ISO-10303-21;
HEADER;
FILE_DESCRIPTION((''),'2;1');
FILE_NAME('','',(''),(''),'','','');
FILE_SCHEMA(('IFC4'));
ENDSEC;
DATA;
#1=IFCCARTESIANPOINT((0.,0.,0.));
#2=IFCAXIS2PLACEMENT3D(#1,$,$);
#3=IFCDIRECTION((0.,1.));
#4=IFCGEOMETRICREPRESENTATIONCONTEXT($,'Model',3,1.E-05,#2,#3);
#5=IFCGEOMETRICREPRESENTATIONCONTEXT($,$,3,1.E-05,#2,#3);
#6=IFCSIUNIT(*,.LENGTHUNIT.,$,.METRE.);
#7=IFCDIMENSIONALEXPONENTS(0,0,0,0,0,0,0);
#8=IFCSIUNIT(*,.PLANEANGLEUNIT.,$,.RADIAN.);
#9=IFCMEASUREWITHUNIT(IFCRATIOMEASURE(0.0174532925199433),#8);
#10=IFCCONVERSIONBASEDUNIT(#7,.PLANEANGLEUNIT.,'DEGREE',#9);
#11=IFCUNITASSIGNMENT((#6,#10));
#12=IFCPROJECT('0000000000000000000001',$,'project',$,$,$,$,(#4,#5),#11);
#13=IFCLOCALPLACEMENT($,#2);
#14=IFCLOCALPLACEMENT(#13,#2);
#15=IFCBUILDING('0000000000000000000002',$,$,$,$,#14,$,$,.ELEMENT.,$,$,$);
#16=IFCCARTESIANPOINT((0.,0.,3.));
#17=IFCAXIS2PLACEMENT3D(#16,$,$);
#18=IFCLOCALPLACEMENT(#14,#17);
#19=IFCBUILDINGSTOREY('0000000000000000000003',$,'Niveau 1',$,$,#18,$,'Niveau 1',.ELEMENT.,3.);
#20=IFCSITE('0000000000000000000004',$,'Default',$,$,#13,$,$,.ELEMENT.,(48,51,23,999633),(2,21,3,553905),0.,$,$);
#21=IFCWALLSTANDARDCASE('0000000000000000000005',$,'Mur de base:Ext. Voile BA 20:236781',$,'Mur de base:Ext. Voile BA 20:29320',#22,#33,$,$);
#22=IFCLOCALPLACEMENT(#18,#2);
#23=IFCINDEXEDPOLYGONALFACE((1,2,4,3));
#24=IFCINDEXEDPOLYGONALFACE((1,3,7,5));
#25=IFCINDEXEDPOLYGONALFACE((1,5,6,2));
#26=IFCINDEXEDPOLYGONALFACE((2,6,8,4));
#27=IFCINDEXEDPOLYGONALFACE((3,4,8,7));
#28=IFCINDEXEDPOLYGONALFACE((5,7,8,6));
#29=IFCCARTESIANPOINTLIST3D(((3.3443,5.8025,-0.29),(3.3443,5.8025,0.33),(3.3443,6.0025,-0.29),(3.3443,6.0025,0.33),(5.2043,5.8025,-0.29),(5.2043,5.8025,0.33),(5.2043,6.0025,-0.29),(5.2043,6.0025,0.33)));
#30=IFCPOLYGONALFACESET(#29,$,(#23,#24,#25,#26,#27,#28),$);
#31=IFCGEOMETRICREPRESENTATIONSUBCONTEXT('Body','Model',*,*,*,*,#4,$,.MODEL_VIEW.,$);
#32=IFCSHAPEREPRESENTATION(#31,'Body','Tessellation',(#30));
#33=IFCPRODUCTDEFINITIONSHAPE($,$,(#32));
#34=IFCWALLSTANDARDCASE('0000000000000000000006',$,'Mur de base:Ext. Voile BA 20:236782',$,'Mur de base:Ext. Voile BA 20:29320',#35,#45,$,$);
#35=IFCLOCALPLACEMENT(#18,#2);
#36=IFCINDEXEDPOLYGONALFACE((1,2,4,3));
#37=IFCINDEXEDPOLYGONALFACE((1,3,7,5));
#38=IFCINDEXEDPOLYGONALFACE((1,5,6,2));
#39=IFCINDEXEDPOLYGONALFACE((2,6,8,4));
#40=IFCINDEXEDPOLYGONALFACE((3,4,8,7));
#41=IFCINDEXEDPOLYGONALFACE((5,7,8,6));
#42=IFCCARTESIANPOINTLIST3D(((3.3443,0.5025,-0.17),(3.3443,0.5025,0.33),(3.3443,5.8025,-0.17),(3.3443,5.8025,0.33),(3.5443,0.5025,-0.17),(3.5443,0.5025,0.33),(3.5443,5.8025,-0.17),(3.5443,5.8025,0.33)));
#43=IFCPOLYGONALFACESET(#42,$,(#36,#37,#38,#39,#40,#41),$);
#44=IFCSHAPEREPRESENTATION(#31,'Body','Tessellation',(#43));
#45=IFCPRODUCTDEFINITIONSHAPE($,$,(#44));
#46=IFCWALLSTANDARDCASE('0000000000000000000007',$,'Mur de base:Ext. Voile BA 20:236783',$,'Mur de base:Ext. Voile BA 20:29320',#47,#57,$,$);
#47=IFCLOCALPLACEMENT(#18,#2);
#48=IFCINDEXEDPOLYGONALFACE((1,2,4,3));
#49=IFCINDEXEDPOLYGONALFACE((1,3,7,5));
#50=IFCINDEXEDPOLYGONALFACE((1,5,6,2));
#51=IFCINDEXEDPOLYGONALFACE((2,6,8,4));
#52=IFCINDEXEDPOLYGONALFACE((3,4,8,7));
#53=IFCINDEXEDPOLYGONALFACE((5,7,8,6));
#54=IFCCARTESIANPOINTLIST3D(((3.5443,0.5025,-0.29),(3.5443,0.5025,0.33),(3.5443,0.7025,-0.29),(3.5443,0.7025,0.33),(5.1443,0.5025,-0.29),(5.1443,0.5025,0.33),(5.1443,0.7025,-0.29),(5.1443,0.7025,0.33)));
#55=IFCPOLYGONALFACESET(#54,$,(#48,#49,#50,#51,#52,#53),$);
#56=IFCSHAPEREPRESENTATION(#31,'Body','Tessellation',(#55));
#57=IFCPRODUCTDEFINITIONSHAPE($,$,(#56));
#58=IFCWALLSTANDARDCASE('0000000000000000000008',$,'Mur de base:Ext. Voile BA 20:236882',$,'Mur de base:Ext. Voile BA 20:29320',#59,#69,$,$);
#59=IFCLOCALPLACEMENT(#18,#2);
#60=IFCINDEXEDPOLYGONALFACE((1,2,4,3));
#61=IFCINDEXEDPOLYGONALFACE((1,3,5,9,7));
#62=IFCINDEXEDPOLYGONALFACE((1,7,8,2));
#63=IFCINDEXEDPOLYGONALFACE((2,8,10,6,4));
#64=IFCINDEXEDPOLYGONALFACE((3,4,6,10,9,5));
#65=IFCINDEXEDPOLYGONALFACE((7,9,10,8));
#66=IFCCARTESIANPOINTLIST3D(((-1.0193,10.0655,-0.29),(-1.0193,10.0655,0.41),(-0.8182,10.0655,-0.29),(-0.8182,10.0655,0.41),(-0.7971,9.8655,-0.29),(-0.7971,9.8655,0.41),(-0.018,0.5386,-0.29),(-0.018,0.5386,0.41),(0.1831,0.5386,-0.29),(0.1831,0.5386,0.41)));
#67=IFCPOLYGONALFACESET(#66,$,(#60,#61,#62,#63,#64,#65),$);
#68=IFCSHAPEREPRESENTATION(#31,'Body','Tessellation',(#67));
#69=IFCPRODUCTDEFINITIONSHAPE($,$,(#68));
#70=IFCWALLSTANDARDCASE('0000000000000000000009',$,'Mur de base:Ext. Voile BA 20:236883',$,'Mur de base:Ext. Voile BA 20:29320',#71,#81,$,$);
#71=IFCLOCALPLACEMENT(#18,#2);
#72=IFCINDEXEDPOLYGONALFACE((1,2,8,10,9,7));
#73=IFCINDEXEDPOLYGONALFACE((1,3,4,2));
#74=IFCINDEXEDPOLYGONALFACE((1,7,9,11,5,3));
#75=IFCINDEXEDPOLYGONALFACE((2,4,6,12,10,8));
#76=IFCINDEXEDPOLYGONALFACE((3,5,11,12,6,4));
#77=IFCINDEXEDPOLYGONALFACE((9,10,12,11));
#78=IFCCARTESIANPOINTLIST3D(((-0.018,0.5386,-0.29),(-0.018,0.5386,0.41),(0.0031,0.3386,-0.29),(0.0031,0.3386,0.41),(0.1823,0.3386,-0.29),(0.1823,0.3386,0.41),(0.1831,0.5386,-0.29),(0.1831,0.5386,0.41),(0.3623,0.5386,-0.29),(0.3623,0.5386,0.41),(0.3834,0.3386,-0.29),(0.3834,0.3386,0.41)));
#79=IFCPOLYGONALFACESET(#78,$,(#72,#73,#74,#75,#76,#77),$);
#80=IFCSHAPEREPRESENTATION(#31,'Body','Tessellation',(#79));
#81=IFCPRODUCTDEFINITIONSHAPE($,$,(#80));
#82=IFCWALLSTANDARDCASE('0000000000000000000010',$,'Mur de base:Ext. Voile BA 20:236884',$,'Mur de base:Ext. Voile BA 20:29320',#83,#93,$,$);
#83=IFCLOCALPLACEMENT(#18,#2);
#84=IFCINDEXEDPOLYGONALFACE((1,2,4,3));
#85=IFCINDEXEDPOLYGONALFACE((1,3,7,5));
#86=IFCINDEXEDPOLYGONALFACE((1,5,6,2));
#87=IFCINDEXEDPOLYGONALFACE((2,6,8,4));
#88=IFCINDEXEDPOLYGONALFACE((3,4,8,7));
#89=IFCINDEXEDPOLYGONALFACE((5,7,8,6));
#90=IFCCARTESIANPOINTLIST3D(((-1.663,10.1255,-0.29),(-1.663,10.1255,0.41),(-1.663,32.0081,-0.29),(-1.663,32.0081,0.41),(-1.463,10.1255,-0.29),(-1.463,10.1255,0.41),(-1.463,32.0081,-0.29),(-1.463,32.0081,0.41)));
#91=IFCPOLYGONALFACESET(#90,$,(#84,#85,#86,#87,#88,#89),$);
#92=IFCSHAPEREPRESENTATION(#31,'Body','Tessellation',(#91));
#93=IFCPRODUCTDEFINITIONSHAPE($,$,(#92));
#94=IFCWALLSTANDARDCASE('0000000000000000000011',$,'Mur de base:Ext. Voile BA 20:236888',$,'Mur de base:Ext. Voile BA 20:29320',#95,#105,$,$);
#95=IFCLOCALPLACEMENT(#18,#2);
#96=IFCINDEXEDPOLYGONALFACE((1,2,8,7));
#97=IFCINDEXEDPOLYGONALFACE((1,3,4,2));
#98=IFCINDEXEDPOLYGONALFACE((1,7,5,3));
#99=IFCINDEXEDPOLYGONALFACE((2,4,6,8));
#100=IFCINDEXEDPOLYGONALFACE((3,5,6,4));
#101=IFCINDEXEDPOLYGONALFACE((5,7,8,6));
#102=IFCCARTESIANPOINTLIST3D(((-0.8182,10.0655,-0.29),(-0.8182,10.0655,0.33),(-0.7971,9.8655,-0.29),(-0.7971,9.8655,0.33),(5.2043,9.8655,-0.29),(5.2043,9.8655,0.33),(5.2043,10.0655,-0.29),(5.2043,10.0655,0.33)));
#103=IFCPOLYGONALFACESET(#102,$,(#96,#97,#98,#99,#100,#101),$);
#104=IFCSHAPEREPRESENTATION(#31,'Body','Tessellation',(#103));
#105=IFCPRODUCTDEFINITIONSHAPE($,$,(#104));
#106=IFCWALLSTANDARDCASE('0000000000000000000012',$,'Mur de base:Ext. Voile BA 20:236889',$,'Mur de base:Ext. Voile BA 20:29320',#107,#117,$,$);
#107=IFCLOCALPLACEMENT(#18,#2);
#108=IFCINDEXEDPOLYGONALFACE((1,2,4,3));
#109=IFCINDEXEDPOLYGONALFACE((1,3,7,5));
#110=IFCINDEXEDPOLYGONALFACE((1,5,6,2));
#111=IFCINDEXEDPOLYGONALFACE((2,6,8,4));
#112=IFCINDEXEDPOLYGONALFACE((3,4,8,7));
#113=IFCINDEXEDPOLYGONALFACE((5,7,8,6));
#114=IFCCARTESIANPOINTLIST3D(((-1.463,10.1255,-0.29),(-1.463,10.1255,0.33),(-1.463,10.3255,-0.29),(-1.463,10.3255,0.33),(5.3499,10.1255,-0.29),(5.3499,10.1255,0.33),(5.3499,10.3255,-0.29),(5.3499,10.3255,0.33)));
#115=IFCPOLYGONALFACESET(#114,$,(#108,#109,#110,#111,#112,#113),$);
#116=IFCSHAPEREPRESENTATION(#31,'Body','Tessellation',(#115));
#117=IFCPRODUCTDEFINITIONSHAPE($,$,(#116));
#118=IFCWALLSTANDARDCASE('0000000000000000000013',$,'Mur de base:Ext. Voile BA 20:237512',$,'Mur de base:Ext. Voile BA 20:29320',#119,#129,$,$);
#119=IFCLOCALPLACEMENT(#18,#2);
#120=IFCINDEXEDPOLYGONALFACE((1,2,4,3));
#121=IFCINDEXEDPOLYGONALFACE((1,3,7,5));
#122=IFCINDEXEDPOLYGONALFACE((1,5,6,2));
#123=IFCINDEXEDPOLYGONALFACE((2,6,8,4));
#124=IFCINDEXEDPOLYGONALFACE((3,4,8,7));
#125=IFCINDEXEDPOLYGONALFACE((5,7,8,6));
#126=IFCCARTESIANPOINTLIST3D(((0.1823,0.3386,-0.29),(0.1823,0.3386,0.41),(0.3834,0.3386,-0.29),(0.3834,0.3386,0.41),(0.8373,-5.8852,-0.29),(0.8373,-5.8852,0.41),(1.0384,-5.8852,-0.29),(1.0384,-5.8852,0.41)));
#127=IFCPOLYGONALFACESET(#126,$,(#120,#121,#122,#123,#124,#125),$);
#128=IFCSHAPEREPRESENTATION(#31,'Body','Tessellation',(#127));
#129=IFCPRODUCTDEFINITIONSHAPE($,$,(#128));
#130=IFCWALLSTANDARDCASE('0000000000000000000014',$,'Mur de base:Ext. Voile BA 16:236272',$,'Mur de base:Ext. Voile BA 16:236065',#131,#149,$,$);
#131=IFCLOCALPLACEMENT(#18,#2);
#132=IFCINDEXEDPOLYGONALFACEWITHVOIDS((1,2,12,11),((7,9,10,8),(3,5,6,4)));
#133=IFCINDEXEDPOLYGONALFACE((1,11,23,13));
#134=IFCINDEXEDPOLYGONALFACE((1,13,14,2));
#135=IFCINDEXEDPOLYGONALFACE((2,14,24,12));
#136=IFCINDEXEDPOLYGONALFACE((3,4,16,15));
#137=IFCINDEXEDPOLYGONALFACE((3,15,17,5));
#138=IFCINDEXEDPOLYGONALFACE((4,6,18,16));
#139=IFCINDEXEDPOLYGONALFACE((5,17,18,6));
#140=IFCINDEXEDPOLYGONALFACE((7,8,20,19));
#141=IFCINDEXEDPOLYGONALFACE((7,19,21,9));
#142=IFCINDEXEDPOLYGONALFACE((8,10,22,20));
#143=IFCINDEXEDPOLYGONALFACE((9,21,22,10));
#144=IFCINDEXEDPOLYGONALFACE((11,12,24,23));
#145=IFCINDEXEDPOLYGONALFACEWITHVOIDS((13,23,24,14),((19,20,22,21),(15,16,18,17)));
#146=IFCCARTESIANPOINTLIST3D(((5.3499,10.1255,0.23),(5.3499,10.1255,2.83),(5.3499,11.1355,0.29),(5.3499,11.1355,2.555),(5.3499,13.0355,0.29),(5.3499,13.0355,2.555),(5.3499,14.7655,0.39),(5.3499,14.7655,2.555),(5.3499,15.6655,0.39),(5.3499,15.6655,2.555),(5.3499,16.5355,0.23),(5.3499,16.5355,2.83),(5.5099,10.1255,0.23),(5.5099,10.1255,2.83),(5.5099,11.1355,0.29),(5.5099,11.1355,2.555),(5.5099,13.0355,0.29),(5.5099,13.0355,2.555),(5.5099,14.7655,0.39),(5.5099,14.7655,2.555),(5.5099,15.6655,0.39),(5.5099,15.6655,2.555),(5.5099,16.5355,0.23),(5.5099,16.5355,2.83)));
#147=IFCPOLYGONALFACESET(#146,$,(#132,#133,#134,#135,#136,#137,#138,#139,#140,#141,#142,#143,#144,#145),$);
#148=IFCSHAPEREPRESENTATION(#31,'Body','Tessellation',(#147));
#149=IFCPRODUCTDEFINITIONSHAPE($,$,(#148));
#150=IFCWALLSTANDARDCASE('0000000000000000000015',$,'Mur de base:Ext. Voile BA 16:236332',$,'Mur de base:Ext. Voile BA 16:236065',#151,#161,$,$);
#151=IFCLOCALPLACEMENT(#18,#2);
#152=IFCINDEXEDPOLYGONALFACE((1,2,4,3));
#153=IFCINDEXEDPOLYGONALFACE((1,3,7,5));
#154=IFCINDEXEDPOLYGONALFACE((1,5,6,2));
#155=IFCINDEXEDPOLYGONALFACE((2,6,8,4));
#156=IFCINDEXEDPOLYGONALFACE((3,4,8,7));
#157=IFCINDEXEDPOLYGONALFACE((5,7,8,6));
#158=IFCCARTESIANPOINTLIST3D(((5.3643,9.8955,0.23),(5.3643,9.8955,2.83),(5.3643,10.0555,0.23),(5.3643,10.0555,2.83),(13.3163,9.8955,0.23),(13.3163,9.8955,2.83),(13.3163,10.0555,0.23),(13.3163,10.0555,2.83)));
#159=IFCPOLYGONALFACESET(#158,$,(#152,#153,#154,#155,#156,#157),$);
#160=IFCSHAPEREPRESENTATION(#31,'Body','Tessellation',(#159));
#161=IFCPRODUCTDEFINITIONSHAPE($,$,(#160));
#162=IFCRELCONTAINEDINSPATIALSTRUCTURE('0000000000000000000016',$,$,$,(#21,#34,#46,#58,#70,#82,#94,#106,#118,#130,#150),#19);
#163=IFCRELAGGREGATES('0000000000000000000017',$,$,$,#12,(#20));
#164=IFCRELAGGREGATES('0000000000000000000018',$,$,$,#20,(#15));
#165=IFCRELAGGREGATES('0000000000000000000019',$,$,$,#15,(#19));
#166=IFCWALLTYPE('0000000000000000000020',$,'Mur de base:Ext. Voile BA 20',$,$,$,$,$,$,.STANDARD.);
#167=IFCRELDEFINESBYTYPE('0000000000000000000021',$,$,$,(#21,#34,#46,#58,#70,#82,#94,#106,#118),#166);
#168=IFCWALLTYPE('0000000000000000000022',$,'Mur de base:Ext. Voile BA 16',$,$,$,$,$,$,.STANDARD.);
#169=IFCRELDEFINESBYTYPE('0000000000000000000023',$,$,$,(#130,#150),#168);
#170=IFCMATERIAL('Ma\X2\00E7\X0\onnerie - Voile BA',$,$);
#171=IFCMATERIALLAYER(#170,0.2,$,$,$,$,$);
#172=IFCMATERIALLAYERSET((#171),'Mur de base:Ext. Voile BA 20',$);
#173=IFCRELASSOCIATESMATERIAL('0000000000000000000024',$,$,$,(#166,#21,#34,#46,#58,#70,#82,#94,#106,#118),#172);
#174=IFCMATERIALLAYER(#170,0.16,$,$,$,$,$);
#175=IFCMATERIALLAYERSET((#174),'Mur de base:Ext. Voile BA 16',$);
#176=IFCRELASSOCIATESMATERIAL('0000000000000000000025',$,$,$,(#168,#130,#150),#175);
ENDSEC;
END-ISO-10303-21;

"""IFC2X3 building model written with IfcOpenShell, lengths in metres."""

from ifc_helpers import new_model, entity, si_unit, converted_unit, direction, frame, frame_2d, origin, place, context, subcontext, project, spatial, polyline, rectangle, outline, extrude, material, layer, layer_set, layer_usage, type_object, element, save


model = new_model("IFC2X3")

# Units and contexts
model_context = context("Model", 3, precision=1e-05, world=origin(), true_north=direction((0.0, 1.0)))
context_of_model = context(None, 3, precision=1e-05, world=origin(), true_north=direction((0.0, 1.0)))
body_context = subcontext(model_context, "Body", "Model", "MODEL_VIEW")
ifc_project = project(units=[si_unit("LENGTHUNIT", "METRE"), converted_unit("PLANEANGLEUNIT", "DEGREE", entity("IfcRatioMeasure", 0.0174532925199433), si_unit("PLANEANGLEUNIT", "RADIAN"), dimensions=[0, 0, 0, 0, 0, 0, 0])], contexts=[model_context, context_of_model])

# Site, building, storey
site_placement = place(None, origin())
site = spatial("IfcSite", under=ifc_project, at=site_placement, Name="Default", CompositionType="ELEMENT", RefLatitude=(48, 51, 23, 999633), RefLongitude=(2, 21, 3, 553905), RefElevation=0.0)
building_placement = place(site_placement, origin())
building = spatial("IfcBuilding", under=site, at=building_placement, CompositionType="ELEMENT")
storey_placement = place(building_placement, frame((0.0, 0.0, 3.0)))
storey = spatial("IfcBuildingStorey", under=building, at=storey_placement, Name="Niveau 1", LongName="Niveau 1", CompositionType="ELEMENT", Elevation=3.0)

# Shared definitions
ifc_material_1 = material(Name="Maçonnerie - Voile BA")
ifc_layer_1 = layer(ifc_material_1, 0.2)
ifc_layer_set_1 = layer_set([ifc_layer_1], Name="Mur de base:Ext. Voile BA 20")
wall_type_1 = type_object("IfcWallType", Name="Mur de base:Ext. Voile BA 20", PredefinedType="STANDARD", material=ifc_layer_set_1)

# Walls
ifc_layer_usage_1 = layer_usage(ifc_layer_set_1, "AXIS2", "NEGATIVE", 0.1)
wall_1_placement = place(storey_placement, frame((5.2043, 5.9025, -0.29), z_axis=(0.0, 0.0, 1.0), x_axis=(-1.0, 0.0, 0.0)))
element("IfcWallStandardCase", 1, at=wall_1_placement, inside=storey, type_object=wall_type_1, material=ifc_layer_usage_1, Name="Mur de base:Ext. Voile BA 20:236781", ObjectType="Mur de base:Ext. Voile BA 20:29320", context=body_context, shape_type="SweptSolid", body=[
    extrude(rectangle(XDim=1.86, YDim=0.2, at=frame_2d((0.93, 0.0), x_axis=(-1.0, 0.0))), origin(), (0.0, 0.0, 1.0), 0.62),
])
ifc_layer_usage_2 = layer_usage(ifc_layer_set_1, "AXIS2", "NEGATIVE", 0.1)
wall_2_placement = place(storey_placement, frame((3.4443, 5.8025, -0.17), z_axis=(0.0, 0.0, 1.0), x_axis=(0.0, -1.0, 0.0)))
element("IfcWallStandardCase", 2, at=wall_2_placement, inside=storey, type_object=wall_type_1, material=ifc_layer_usage_2, Name="Mur de base:Ext. Voile BA 20:236782", ObjectType="Mur de base:Ext. Voile BA 20:29320", context=body_context, shape_type="SweptSolid", body=[
    extrude(rectangle(XDim=5.3, YDim=0.2, at=frame_2d((2.65, 0.0), x_axis=(-1.0, 0.0))), origin(), (0.0, 0.0, 1.0), 0.5),
])
ifc_layer_usage_3 = layer_usage(ifc_layer_set_1, "AXIS2", "NEGATIVE", 0.1)
wall_3_placement = place(storey_placement, frame((3.5443, 0.6025, -0.29)))
element("IfcWallStandardCase", 3, at=wall_3_placement, inside=storey, type_object=wall_type_1, material=ifc_layer_usage_3, Name="Mur de base:Ext. Voile BA 20:236783", ObjectType="Mur de base:Ext. Voile BA 20:29320", context=body_context, shape_type="SweptSolid", body=[
    extrude(rectangle(XDim=1.6, YDim=0.2, at=frame_2d((0.8, 0.0), x_axis=(-1.0, 0.0))), origin(), (0.0, 0.0, 1.0), 0.62),
])
ifc_layer_usage_4 = layer_usage(ifc_layer_set_1, "AXIS2", "NEGATIVE", 0.1)
wall_4_placement = place(storey_placement, frame((0.0837, 0.5282, -0.29), z_axis=(0.0, 0.0, 1.0), x_axis=(-0.104528, 0.994522, 0.0)))
element("IfcWallStandardCase", 4, at=wall_4_placement, inside=storey, type_object=wall_type_1, material=ifc_layer_usage_4, Name="Mur de base:Ext. Voile BA 20:236882", ObjectType="Mur de base:Ext. Voile BA 20:29320", context=body_context, shape_type="SweptSolid", body=[
    extrude(outline(polyline([(9.5793, -0.1), (9.6003, 0.1), (0.021, 0.1), (0.0, -0.1), (9.3782, -0.1), (9.5793, -0.1)])), origin(), (0.0, 0.0, 1.0), 0.7),
])
ifc_layer_usage_5 = layer_usage(ifc_layer_set_1, "AXIS2", "POSITIVE", -0.1)
wall_5_placement = place(storey_placement, frame((-0.018, 0.4386, -0.29)))
element("IfcWallStandardCase", 5, at=wall_5_placement, inside=storey, type_object=wall_type_1, material=ifc_layer_usage_5, Name="Mur de base:Ext. Voile BA 20:236883", ObjectType="Mur de base:Ext. Voile BA 20:29320", context=body_context, shape_type="SweptSolid", body=[
    extrude(outline(polyline([(0.4013, -0.1), (0.3803, 0.1), (0.2011, 0.1), (0.0, 0.1), (0.021, -0.1), (0.2002, -0.1), (0.4013, -0.1)])), origin(), (0.0, 0.0, 1.0), 0.7),
])
ifc_layer_usage_6 = layer_usage(ifc_layer_set_1, "AXIS2", "NEGATIVE", 0.1)
wall_6_placement = place(storey_placement, frame((-1.563, 10.1255, -0.29), z_axis=(0.0, 0.0, 1.0), x_axis=(0.0, 1.0, 0.0)))
element("IfcWallStandardCase", 6, at=wall_6_placement, inside=storey, type_object=wall_type_1, material=ifc_layer_usage_6, Name="Mur de base:Ext. Voile BA 20:236884", ObjectType="Mur de base:Ext. Voile BA 20:29320", context=body_context, shape_type="SweptSolid", body=[
    extrude(rectangle(XDim=21.8826, YDim=0.2, at=frame_2d((10.9413, 0.0), x_axis=(-1.0, 0.0))), origin(), (0.0, 0.0, 1.0), 0.7),
])
ifc_layer_usage_7 = layer_usage(ifc_layer_set_1, "AXIS2", "NEGATIVE", 0.1)
wall_7_placement = place(storey_placement, frame((-0.8182, 9.9655, -0.29)))
element("IfcWallStandardCase", 7, at=wall_7_placement, inside=storey, type_object=wall_type_1, material=ifc_layer_usage_7, Name="Mur de base:Ext. Voile BA 20:236888", ObjectType="Mur de base:Ext. Voile BA 20:29320", context=body_context, shape_type="SweptSolid", body=[
    extrude(outline(polyline([(6.0224, -0.1), (6.0224, 0.1), (0.0, 0.1), (0.021, -0.1), (6.0224, -0.1)])), origin(), (0.0, 0.0, 1.0), 0.62),
])
ifc_layer_usage_8 = layer_usage(ifc_layer_set_1, "AXIS2", "NEGATIVE", 0.1)
wall_8_placement = place(storey_placement, frame((5.3499, 10.2255, -0.29), z_axis=(0.0, 0.0, 1.0), x_axis=(-1.0, 0.0, 0.0)))
element("IfcWallStandardCase", 8, at=wall_8_placement, inside=storey, type_object=wall_type_1, material=ifc_layer_usage_8, Name="Mur de base:Ext. Voile BA 20:236889", ObjectType="Mur de base:Ext. Voile BA 20:29320", context=body_context, shape_type="SweptSolid", body=[
    extrude(rectangle(XDim=6.8129, YDim=0.2, at=frame_2d((3.4064, 0.0), x_axis=(-1.0, 0.0))), origin(), (0.0, 0.0, 1.0), 0.62),
])
ifc_layer_usage_9 = layer_usage(ifc_layer_set_1, "AXIS2", "NEGATIVE", 0.1)
wall_9_placement = place(storey_placement, frame((0.939, -5.8956, -0.29), z_axis=(0.0, 0.0, 1.0), x_axis=(-0.104671, 0.994507, 0.0)))
element("IfcWallStandardCase", 9, at=wall_9_placement, inside=storey, type_object=wall_type_1, material=ifc_layer_usage_9, Name="Mur de base:Ext. Voile BA 20:237512", ObjectType="Mur de base:Ext. Voile BA 20:29320", context=body_context, shape_type="SweptSolid", body=[
    extrude(outline(polyline([(6.2582, -0.1), (6.2792, 0.1), (0.021, 0.1), (0.0, -0.1), (6.2582, -0.1)])), origin(), (0.0, 0.0, 1.0), 0.7),
])

# Wall, openings
ifc_layer_2 = layer(ifc_material_1, 0.16)
ifc_layer_set_2 = layer_set([ifc_layer_2], Name="Mur de base:Ext. Voile BA 16")
ifc_layer_usage_10 = layer_usage(ifc_layer_set_2, "AXIS2", "NEGATIVE", 0.08)
wall_type_2 = type_object("IfcWallType", Name="Mur de base:Ext. Voile BA 16", PredefinedType="STANDARD", material=ifc_layer_set_2)
wall_10_placement = place(storey_placement, frame((5.4299, 10.1255, 0.23), z_axis=(0.0, 0.0, 1.0), x_axis=(0.0, 1.0, 0.0)))
wall_10 = element("IfcWallStandardCase", 10, at=wall_10_placement, inside=storey, type_object=wall_type_2, material=ifc_layer_usage_10, Name="Mur de base:Ext. Voile BA 16:236272", ObjectType="Mur de base:Ext. Voile BA 16:236065", context=body_context, shape_type="SweptSolid", body=[
    extrude(rectangle(XDim=6.41, YDim=0.16, at=frame_2d((3.205, 0.0), x_axis=(-1.0, 0.0))), origin(), (0.0, 0.0, 1.0), 2.6),
])
opening_1_placement = place(wall_10_placement, origin())
element("IfcOpeningElement", 11, at=opening_1_placement, cuts=wall_10, ObjectType="Opening", context=body_context, shape_type="SweptSolid", body=[
    extrude(rectangle(XDim=2.165, YDim=0.9, at=frame_2d((0.0, 0.0), x_axis=(1.0, 0.0))), frame((5.09, -0.08, 1.2425), z_axis=(0.0, 1.0, 0.0), x_axis=(0.0, 0.0, -1.0)), (0.0, 0.0, 1.0), 0.16),
])
opening_2_placement = place(wall_10_placement, origin())
element("IfcOpeningElement", 12, at=opening_2_placement, cuts=wall_10, ObjectType="Opening", context=body_context, shape_type="SweptSolid", body=[
    extrude(rectangle(XDim=2.265, YDim=1.9, at=frame_2d((0.0, 0.0), x_axis=(1.0, 0.0))), frame((1.96, -0.08, 1.1925), z_axis=(0.0, 1.0, 0.0), x_axis=(0.0, 0.0, -1.0)), (0.0, 0.0, 1.0), 0.16),
])

# Wall
ifc_layer_usage_11 = layer_usage(ifc_layer_set_2, "AXIS2", "NEGATIVE", 0.08)
wall_11_placement = place(storey_placement, frame((5.3643, 9.9755, 0.23)))
element("IfcWallStandardCase", 13, at=wall_11_placement, inside=storey, type_object=wall_type_2, material=ifc_layer_usage_11, Name="Mur de base:Ext. Voile BA 16:236332", ObjectType="Mur de base:Ext. Voile BA 16:236065", context=body_context, shape_type="SweptSolid", body=[
    extrude(rectangle(XDim=7.952, YDim=0.16, at=frame_2d((3.976, 0.0), x_axis=(-1.0, 0.0))), origin(), (0.0, 0.0, 1.0), 2.6),
])

save(model, "model.ifc")
